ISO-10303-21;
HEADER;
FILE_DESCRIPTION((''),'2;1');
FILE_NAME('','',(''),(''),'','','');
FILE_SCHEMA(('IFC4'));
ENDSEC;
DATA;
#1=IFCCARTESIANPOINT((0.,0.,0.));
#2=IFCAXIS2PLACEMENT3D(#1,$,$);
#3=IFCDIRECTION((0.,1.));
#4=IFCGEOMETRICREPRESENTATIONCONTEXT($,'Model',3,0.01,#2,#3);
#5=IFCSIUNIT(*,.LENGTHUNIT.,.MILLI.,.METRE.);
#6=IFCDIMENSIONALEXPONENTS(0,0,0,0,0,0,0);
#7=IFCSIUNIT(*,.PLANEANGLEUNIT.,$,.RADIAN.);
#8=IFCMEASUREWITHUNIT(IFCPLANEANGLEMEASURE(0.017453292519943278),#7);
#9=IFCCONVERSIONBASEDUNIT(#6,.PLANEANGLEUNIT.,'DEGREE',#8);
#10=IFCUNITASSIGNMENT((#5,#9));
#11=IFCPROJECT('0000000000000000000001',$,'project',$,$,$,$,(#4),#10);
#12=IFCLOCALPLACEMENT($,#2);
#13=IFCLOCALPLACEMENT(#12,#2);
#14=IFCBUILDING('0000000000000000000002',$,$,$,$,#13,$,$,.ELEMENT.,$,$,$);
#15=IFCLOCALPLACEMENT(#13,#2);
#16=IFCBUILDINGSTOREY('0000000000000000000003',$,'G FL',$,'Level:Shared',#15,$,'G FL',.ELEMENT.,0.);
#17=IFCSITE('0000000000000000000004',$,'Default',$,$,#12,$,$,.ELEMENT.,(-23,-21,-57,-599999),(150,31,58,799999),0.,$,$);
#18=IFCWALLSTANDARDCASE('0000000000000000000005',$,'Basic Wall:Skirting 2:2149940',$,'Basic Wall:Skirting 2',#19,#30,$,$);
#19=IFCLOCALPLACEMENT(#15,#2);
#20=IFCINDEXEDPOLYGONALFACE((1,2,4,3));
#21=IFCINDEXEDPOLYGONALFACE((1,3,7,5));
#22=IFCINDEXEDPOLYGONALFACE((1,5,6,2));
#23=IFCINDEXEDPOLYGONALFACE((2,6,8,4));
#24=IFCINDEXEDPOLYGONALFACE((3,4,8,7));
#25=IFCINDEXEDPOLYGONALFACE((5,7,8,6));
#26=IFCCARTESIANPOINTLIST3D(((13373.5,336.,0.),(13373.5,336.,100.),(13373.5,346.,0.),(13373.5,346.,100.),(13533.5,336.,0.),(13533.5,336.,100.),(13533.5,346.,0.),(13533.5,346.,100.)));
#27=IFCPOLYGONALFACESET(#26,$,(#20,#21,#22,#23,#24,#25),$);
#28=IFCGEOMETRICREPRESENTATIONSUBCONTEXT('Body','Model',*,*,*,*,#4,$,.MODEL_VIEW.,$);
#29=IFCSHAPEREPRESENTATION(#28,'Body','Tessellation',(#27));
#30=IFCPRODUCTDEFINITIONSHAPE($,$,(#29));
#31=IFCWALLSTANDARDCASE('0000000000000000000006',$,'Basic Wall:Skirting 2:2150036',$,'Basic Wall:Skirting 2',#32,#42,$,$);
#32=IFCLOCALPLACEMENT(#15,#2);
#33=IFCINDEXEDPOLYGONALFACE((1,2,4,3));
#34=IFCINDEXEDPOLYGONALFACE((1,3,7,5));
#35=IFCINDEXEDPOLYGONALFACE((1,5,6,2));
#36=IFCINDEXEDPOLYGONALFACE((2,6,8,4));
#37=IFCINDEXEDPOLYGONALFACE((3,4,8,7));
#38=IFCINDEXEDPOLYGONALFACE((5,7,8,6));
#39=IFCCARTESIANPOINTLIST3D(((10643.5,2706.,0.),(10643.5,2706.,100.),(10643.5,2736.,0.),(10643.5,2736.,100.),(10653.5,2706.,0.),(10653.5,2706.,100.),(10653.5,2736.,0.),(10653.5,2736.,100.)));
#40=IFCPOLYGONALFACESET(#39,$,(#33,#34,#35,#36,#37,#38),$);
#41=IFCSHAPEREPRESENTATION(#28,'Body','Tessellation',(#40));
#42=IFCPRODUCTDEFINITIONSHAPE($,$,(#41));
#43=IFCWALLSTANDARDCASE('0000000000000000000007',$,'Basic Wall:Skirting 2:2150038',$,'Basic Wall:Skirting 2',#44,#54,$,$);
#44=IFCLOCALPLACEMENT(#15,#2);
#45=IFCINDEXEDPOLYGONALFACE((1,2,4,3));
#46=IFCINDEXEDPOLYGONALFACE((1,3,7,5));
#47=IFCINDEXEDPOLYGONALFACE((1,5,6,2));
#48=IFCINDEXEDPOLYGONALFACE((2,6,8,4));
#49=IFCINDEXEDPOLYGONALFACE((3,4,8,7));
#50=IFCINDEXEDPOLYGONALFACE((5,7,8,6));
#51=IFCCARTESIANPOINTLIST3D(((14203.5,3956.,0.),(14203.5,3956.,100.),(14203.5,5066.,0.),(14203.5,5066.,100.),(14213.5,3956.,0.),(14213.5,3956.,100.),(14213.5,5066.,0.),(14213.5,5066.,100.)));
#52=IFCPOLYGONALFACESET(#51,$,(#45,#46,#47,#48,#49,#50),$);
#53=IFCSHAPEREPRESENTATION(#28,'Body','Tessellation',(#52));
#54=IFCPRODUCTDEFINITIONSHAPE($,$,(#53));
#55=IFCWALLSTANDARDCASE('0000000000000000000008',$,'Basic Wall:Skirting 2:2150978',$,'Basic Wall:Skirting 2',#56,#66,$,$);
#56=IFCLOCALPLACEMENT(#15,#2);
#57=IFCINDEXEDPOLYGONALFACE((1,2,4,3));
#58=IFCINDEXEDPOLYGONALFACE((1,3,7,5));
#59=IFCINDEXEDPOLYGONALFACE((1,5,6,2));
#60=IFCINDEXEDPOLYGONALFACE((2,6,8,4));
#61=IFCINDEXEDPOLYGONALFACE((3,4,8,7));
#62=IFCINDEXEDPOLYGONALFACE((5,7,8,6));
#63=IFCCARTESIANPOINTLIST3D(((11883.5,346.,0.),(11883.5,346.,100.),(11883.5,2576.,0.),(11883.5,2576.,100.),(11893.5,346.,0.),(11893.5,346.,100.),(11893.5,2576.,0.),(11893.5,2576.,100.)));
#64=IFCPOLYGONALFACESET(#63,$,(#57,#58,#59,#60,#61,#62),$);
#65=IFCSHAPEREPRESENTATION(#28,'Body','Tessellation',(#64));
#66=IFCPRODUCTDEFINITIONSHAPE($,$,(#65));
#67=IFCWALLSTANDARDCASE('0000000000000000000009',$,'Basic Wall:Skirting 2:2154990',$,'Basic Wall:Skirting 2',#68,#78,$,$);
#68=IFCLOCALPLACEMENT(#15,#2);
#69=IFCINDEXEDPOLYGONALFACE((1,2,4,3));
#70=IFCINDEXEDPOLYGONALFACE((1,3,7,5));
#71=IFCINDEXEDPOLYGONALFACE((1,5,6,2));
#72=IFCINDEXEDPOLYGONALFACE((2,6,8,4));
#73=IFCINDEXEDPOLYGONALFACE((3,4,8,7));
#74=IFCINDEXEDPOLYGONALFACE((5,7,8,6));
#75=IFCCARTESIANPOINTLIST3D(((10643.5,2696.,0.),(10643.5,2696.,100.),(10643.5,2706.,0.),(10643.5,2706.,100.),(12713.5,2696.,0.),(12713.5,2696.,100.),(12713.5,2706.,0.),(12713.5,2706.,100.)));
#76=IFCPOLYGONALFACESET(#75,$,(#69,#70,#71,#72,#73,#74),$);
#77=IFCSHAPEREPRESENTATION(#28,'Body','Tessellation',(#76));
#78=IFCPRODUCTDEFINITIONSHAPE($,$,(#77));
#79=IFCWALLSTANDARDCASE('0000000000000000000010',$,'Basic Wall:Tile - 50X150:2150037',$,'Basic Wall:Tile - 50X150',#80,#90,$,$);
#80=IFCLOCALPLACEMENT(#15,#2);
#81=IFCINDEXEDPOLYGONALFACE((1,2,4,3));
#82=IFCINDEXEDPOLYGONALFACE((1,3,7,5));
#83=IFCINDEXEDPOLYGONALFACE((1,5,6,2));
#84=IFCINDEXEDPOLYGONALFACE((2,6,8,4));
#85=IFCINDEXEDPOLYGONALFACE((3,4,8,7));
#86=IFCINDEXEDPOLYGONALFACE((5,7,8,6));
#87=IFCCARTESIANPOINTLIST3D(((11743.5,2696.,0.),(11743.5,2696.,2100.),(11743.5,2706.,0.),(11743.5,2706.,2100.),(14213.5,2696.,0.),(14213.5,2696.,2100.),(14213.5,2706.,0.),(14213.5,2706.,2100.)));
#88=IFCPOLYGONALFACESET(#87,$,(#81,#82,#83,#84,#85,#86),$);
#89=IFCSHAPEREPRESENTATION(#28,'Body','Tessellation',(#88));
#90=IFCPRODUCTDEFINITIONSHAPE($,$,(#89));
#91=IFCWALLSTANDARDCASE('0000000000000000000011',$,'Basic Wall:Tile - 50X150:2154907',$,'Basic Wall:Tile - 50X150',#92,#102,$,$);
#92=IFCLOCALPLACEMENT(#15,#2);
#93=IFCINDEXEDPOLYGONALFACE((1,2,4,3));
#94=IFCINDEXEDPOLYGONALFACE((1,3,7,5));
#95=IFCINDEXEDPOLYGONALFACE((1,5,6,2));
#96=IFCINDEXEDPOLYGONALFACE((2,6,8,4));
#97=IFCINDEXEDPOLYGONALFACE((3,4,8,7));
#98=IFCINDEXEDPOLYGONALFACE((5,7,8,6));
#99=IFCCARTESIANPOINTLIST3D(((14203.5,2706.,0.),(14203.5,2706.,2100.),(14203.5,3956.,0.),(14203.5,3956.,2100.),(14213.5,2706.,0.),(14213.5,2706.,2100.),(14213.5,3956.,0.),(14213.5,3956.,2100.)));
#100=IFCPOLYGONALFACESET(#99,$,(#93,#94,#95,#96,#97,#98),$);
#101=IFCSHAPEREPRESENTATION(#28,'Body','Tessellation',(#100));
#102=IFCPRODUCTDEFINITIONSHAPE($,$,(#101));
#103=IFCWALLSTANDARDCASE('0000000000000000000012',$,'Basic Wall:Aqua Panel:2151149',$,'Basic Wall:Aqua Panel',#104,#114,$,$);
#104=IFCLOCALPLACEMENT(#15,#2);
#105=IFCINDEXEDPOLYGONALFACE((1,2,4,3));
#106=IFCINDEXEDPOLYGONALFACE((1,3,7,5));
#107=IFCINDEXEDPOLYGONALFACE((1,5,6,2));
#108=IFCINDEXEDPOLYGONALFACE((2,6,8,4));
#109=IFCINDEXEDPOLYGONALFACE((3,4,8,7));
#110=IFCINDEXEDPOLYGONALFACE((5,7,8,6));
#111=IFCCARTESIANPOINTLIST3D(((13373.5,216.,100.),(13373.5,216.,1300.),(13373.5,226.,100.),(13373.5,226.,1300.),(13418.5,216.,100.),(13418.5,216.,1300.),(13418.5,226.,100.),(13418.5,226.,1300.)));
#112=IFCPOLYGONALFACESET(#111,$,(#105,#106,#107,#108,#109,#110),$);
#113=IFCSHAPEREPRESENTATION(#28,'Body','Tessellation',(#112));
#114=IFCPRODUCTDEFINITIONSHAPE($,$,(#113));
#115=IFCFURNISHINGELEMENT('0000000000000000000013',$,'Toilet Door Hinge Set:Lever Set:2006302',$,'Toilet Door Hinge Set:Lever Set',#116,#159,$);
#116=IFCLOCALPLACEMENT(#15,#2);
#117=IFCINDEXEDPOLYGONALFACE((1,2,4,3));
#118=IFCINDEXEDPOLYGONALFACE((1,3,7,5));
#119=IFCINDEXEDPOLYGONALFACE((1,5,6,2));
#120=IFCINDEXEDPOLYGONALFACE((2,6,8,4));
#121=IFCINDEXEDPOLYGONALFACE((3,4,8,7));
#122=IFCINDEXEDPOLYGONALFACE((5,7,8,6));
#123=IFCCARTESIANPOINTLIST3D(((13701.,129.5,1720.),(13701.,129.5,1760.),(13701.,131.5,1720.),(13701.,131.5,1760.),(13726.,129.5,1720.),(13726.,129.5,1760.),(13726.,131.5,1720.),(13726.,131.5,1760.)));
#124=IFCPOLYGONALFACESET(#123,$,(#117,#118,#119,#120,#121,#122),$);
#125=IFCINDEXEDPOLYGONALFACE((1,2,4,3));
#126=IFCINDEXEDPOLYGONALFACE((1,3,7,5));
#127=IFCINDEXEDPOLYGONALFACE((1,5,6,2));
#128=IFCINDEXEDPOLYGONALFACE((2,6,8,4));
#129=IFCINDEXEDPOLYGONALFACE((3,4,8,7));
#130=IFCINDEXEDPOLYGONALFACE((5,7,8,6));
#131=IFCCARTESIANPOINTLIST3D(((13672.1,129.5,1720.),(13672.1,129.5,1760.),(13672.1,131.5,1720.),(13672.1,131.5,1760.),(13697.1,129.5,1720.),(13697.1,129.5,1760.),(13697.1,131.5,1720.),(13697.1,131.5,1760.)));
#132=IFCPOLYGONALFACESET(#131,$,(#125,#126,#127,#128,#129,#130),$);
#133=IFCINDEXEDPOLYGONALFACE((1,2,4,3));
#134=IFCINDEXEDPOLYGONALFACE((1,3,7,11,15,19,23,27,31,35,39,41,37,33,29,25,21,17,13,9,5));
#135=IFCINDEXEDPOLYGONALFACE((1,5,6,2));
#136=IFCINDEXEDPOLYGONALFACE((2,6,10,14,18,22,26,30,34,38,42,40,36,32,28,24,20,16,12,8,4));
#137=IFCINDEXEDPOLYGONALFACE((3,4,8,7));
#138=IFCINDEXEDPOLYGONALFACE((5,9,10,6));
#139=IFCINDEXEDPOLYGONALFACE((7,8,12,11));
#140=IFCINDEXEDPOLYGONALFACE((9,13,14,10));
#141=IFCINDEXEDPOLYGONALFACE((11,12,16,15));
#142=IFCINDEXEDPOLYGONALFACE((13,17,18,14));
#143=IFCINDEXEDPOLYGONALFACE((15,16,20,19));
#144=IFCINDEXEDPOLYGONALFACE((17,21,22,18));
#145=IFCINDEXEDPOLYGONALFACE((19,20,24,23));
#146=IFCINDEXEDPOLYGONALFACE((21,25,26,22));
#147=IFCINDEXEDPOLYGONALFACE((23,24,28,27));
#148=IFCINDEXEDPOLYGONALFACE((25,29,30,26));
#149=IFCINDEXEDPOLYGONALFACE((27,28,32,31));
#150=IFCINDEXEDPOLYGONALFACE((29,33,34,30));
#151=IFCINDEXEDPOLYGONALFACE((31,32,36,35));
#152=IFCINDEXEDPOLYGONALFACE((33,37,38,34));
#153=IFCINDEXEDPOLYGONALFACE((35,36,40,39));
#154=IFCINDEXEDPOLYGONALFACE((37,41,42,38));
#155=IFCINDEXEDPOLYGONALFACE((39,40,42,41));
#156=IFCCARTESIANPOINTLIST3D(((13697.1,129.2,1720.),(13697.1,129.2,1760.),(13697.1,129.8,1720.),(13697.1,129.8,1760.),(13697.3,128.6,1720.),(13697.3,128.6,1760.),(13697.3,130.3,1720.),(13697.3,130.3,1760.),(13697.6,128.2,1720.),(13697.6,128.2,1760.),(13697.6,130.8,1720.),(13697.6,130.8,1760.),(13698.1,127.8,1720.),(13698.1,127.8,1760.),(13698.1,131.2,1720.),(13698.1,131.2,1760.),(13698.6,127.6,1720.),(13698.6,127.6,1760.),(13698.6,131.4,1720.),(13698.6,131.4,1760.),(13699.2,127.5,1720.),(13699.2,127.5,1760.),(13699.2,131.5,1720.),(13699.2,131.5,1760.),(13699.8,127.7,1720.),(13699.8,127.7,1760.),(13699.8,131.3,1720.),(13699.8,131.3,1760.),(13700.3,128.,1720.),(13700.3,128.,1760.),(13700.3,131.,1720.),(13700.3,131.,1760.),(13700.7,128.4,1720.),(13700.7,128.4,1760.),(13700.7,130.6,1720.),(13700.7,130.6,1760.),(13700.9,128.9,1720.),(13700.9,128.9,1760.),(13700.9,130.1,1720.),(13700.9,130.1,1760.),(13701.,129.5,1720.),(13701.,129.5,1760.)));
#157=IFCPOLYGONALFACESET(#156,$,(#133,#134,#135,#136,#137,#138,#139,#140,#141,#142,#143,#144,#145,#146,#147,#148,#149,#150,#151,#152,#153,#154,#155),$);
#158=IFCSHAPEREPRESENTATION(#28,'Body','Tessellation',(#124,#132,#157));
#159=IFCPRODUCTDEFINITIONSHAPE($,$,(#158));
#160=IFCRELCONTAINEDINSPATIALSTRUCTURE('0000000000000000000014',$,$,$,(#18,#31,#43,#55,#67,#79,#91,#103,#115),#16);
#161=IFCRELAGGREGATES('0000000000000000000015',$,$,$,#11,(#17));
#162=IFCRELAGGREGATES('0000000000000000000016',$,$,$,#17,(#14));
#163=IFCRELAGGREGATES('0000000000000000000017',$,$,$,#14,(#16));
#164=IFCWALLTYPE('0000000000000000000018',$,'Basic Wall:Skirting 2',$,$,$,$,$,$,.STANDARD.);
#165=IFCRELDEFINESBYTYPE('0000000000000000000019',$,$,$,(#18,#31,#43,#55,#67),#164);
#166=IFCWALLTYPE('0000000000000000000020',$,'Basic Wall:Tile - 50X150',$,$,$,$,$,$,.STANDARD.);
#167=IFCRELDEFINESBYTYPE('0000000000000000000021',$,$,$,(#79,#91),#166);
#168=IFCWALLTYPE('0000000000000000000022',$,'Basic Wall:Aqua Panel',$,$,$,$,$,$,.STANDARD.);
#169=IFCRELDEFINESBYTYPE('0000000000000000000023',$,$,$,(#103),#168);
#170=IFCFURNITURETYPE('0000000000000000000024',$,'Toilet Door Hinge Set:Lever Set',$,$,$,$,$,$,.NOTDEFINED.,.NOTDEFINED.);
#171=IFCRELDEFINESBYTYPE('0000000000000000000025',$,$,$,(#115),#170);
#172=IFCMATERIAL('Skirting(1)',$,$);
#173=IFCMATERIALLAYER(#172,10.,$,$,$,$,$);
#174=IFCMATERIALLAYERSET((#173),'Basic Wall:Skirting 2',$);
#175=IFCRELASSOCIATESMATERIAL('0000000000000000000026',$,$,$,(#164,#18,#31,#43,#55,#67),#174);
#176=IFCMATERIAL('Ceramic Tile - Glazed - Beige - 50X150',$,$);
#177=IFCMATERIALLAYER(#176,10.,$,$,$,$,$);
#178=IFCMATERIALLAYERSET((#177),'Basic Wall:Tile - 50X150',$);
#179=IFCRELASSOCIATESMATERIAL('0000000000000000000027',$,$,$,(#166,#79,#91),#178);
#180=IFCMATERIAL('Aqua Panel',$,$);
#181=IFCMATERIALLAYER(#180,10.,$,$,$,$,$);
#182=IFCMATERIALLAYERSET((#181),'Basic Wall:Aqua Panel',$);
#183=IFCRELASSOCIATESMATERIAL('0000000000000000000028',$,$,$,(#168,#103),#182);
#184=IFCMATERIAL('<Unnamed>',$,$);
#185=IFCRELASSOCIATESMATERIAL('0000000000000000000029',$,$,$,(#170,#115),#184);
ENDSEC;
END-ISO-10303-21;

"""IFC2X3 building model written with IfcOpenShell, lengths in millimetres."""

from ifc_helpers import new_model, entity, si_unit, converted_unit, direction, frame, frame_2d, origin, place, context, subcontext, project, spatial, rectangle, circle, extrude, source, transform, mapped, material, layer, layer_set, layer_usage, type_object, type_shapes, element, save


model = new_model("IFC2X3")

# Units and contexts
model_context = context("Model", 3, precision=0.01, world=origin(), true_north=direction((0.0, 1.0)))
body_context = subcontext(model_context, "Body", "Model", "MODEL_VIEW")
ifc_project = project(units=[si_unit("LENGTHUNIT", "METRE", prefix="MILLI"), converted_unit("PLANEANGLEUNIT", "DEGREE", entity("IfcPlaneAngleMeasure", 0.017453292519943278), si_unit("PLANEANGLEUNIT", "RADIAN"), dimensions=[0, 0, 0, 0, 0, 0, 0])], contexts=[model_context])

# Site, building, storey
site_placement = place(None, origin())
site = spatial("IfcSite", under=ifc_project, at=site_placement, Name="Default", CompositionType="ELEMENT", RefLatitude=(-23, -21, -57, -599999), RefLongitude=(150, 31, 58, 799999), RefElevation=0.0)
building_placement = place(site_placement, origin())
building = spatial("IfcBuilding", under=site, at=building_placement, CompositionType="ELEMENT")
storey_placement = place(building_placement, origin())
storey = spatial("IfcBuildingStorey", under=building, at=storey_placement, Name="G FL", ObjectType="Level:Shared", LongName="G FL", CompositionType="ELEMENT", Elevation=0.0)

# Shared definitions
ifc_material_1 = material(Name="Skirting(1)")
ifc_layer_1 = layer(ifc_material_1, 10.0)
ifc_layer_set_1 = layer_set([ifc_layer_1], Name="Basic Wall:Skirting 2")
wall_type_1 = type_object("IfcWallType", Name="Basic Wall:Skirting 2", PredefinedType="STANDARD", material=ifc_layer_set_1)

# Walls
ifc_layer_usage_1 = layer_usage(ifc_layer_set_1, "AXIS2", "NEGATIVE", 5.0)
wall_1_placement = place(storey_placement, frame((13533.5, 341.0, 0.0), z_axis=(0.0, 0.0, 1.0), x_axis=(-1.0, 0.0, 0.0)))
element("IfcWallStandardCase", 1, at=wall_1_placement, inside=storey, type_object=wall_type_1, material=ifc_layer_usage_1, Name="Basic Wall:Skirting 2:2149940", ObjectType="Basic Wall:Skirting 2", context=body_context, shape_type="SweptSolid", body=[
    extrude(rectangle(XDim=160.0, YDim=10.0, at=frame_2d((-6.0, -1.0), x_axis=(1.0, 0.0))), frame((86.0, 1.0, 0.0)), (0.0, 0.0, 1.0), 100.0),
])
ifc_layer_usage_2 = layer_usage(ifc_layer_set_1, "AXIS2", "NEGATIVE", 5.0)
wall_2_placement = place(storey_placement, frame((10648.5, 2706.0, 0.0), z_axis=(0.0, 0.0, 1.0), x_axis=(0.0, 1.0, 0.0)))
element("IfcWallStandardCase", 2, at=wall_2_placement, inside=storey, type_object=wall_type_1, material=ifc_layer_usage_2, Name="Basic Wall:Skirting 2:2150036", ObjectType="Basic Wall:Skirting 2", context=body_context, shape_type="SweptSolid", body=[
    extrude(rectangle(XDim=30.0, YDim=10.0, at=frame_2d((15.0, 0.0), x_axis=(-1.0, 0.0))), origin(), (0.0, 0.0, 1.0), 100.0),
])
ifc_layer_usage_3 = layer_usage(ifc_layer_set_1, "AXIS2", "NEGATIVE", 5.0)
wall_3_placement = place(storey_placement, frame((14208.5, 5066.0, 0.0), z_axis=(0.0, 0.0, 1.0), x_axis=(0.0, -1.0, 0.0)))
element("IfcWallStandardCase", 3, at=wall_3_placement, inside=storey, type_object=wall_type_1, material=ifc_layer_usage_3, Name="Basic Wall:Skirting 2:2150038", ObjectType="Basic Wall:Skirting 2", context=body_context, shape_type="SweptSolid", body=[
    extrude(rectangle(XDim=1110.0, YDim=10.0, at=frame_2d((555.0, 0.0), x_axis=(-1.0, 0.0))), origin(), (0.0, 0.0, 1.0), 100.0),
])
ifc_layer_usage_4 = layer_usage(ifc_layer_set_1, "AXIS2", "NEGATIVE", 5.0)
wall_4_placement = place(storey_placement, frame((11888.5, 346.0, 0.0), z_axis=(0.0, 0.0, 1.0), x_axis=(0.0, 1.0, 0.0)))
element("IfcWallStandardCase", 4, at=wall_4_placement, inside=storey, type_object=wall_type_1, material=ifc_layer_usage_4, Name="Basic Wall:Skirting 2:2150978", ObjectType="Basic Wall:Skirting 2", context=body_context, shape_type="SweptSolid", body=[
    extrude(rectangle(XDim=2230.0, YDim=10.0, at=frame_2d((1115.0, 0.0), x_axis=(-1.0, 0.0))), origin(), (0.0, 0.0, 1.0), 100.0),
])

# Walls
ifc_layer_usage_5 = layer_usage(ifc_layer_set_1, "AXIS2", "NEGATIVE", 5.0)
wall_5_placement = place(storey_placement, frame((12713.5, 2701.0, 0.0), z_axis=(0.0, 0.0, 1.0), x_axis=(-1.0, 0.0, 0.0)))
element("IfcWallStandardCase", 5, at=wall_5_placement, inside=storey, type_object=wall_type_1, material=ifc_layer_usage_5, Name="Basic Wall:Skirting 2:2154990", ObjectType="Basic Wall:Skirting 2", context=body_context, shape_type="SweptSolid", body=[
    extrude(rectangle(XDim=2070.0, YDim=10.0, at=frame_2d((1035.0, 0.0), x_axis=(-1.0, 0.0))), origin(), (0.0, 0.0, 1.0), 100.0),
])
ifc_material_2 = material(Name="Ceramic Tile - Glazed - Beige - 50X150")
ifc_layer_2 = layer(ifc_material_2, 10.0)
ifc_layer_set_2 = layer_set([ifc_layer_2], Name="Basic Wall:Tile - 50X150")
ifc_layer_usage_6 = layer_usage(ifc_layer_set_2, "AXIS2", "NEGATIVE", 5.0)
wall_type_2 = type_object("IfcWallType", Name="Basic Wall:Tile - 50X150", PredefinedType="STANDARD", material=ifc_layer_set_2)
wall_6_placement = place(storey_placement, frame((14213.5, 2701.0, 0.0), z_axis=(0.0, 0.0, 1.0), x_axis=(-1.0, 0.0, 0.0)))
element("IfcWallStandardCase", 6, at=wall_6_placement, inside=storey, type_object=wall_type_2, material=ifc_layer_usage_6, Name="Basic Wall:Tile - 50X150:2150037", ObjectType="Basic Wall:Tile - 50X150", context=body_context, shape_type="SweptSolid", body=[
    extrude(rectangle(XDim=10.0, YDim=2470.0, at=frame_2d((1235.0, 0.0), x_axis=(0.0, -1.0))), origin(), (0.0, 0.0, 1.0), 2100.0),
])
ifc_layer_usage_7 = layer_usage(ifc_layer_set_2, "AXIS2", "NEGATIVE", 5.0)
wall_7_placement = place(storey_placement, frame((14208.5, 3956.0, 0.0), z_axis=(0.0, 0.0, 1.0), x_axis=(0.0, -1.0, 0.0)))
element("IfcWallStandardCase", 7, at=wall_7_placement, inside=storey, type_object=wall_type_2, material=ifc_layer_usage_7, Name="Basic Wall:Tile - 50X150:2154907", ObjectType="Basic Wall:Tile - 50X150", context=body_context, shape_type="SweptSolid", body=[
    extrude(rectangle(XDim=1250.0, YDim=10.0, at=frame_2d((625.0, 0.0), x_axis=(-1.0, 0.0))), origin(), (0.0, 0.0, 1.0), 2100.0),
])

# Wall
ifc_material_3 = material(Name="Aqua Panel")
ifc_layer_3 = layer(ifc_material_3, 10.0)
ifc_layer_set_3 = layer_set([ifc_layer_3], Name="Basic Wall:Aqua Panel")
ifc_layer_usage_8 = layer_usage(ifc_layer_set_3, "AXIS2", "NEGATIVE", 5.0)
wall_type_3 = type_object("IfcWallType", Name="Basic Wall:Aqua Panel", PredefinedType="STANDARD", material=ifc_layer_set_3)
wall_8_placement = place(storey_placement, frame((13373.5, 221.0, 100.0)))
element("IfcWallStandardCase", 8, at=wall_8_placement, inside=storey, type_object=wall_type_3, material=ifc_layer_usage_8, Name="Basic Wall:Aqua Panel:2151149", ObjectType="Basic Wall:Aqua Panel", context=body_context, shape_type="SweptSolid", body=[
    extrude(rectangle(XDim=45.0, YDim=10.0, at=frame_2d((0.0, 0.0), x_axis=(1.0, 0.0))), frame((22.5, 0.0, 0.0), z_axis=(0.0, 0.0, 1.0), x_axis=(-1.0, 0.0, 0.0)), (0.0, 0.0, 1.0), 1200.0),
])

# Furnishing element
ifc_material_4 = material(Name="<Unnamed>")
furniture_type = type_object("IfcFurnitureType", Name="Toilet Door Hinge Set:Lever Set", AssemblyPlace="NOTDEFINED", material=ifc_material_4)
shared_shape_1 = source(origin(), body_context, "Body", "SweptSolid", [
    extrude(rectangle(XDim=2.0, YDim=25.0, at=frame_2d((0.0, 0.0), x_axis=(1.0, 0.0))), frame((14.5, 1.0, -20.0), z_axis=(0.0, 0.0, 1.0), x_axis=(0.0, 1.0, 0.0)), (0.0, 0.0, 1.0), 40.0),
    extrude(rectangle(XDim=25.0, YDim=2.0, at=frame_2d((0.0, 0.0), x_axis=(1.0, 0.0))), frame((-14.5, 1.0, -20.0)), (0.0, 0.0, 1.0), 40.0),
    extrude(circle(Radius=2.0, at=frame_2d((0.0, 0.0), x_axis=(1.0, 0.0))), frame((0.0, 0.0, -20.0)), (0.0, 0.0, 1.0), 40.0),
])
type_shapes(furniture_type, [shared_shape_1])
for number, where, name in (
    (9, (13699.0, 129.5, 1740.0), "Toilet Door Hinge Set:Lever Set:2006302"),
):
    element("IfcFurnishingElement", number, at=place(storey_placement, frame(where)), inside=storey, type_object=furniture_type, material=ifc_material_4, Name=name, ObjectType="Toilet Door Hinge Set:Lever Set", context=body_context, shape_type="MappedRepresentation", body=[
        mapped(shared_shape_1, transform((0.0, 0.0, 0.0), scale=1.0)),
    ])

save(model, "model.ifc")
